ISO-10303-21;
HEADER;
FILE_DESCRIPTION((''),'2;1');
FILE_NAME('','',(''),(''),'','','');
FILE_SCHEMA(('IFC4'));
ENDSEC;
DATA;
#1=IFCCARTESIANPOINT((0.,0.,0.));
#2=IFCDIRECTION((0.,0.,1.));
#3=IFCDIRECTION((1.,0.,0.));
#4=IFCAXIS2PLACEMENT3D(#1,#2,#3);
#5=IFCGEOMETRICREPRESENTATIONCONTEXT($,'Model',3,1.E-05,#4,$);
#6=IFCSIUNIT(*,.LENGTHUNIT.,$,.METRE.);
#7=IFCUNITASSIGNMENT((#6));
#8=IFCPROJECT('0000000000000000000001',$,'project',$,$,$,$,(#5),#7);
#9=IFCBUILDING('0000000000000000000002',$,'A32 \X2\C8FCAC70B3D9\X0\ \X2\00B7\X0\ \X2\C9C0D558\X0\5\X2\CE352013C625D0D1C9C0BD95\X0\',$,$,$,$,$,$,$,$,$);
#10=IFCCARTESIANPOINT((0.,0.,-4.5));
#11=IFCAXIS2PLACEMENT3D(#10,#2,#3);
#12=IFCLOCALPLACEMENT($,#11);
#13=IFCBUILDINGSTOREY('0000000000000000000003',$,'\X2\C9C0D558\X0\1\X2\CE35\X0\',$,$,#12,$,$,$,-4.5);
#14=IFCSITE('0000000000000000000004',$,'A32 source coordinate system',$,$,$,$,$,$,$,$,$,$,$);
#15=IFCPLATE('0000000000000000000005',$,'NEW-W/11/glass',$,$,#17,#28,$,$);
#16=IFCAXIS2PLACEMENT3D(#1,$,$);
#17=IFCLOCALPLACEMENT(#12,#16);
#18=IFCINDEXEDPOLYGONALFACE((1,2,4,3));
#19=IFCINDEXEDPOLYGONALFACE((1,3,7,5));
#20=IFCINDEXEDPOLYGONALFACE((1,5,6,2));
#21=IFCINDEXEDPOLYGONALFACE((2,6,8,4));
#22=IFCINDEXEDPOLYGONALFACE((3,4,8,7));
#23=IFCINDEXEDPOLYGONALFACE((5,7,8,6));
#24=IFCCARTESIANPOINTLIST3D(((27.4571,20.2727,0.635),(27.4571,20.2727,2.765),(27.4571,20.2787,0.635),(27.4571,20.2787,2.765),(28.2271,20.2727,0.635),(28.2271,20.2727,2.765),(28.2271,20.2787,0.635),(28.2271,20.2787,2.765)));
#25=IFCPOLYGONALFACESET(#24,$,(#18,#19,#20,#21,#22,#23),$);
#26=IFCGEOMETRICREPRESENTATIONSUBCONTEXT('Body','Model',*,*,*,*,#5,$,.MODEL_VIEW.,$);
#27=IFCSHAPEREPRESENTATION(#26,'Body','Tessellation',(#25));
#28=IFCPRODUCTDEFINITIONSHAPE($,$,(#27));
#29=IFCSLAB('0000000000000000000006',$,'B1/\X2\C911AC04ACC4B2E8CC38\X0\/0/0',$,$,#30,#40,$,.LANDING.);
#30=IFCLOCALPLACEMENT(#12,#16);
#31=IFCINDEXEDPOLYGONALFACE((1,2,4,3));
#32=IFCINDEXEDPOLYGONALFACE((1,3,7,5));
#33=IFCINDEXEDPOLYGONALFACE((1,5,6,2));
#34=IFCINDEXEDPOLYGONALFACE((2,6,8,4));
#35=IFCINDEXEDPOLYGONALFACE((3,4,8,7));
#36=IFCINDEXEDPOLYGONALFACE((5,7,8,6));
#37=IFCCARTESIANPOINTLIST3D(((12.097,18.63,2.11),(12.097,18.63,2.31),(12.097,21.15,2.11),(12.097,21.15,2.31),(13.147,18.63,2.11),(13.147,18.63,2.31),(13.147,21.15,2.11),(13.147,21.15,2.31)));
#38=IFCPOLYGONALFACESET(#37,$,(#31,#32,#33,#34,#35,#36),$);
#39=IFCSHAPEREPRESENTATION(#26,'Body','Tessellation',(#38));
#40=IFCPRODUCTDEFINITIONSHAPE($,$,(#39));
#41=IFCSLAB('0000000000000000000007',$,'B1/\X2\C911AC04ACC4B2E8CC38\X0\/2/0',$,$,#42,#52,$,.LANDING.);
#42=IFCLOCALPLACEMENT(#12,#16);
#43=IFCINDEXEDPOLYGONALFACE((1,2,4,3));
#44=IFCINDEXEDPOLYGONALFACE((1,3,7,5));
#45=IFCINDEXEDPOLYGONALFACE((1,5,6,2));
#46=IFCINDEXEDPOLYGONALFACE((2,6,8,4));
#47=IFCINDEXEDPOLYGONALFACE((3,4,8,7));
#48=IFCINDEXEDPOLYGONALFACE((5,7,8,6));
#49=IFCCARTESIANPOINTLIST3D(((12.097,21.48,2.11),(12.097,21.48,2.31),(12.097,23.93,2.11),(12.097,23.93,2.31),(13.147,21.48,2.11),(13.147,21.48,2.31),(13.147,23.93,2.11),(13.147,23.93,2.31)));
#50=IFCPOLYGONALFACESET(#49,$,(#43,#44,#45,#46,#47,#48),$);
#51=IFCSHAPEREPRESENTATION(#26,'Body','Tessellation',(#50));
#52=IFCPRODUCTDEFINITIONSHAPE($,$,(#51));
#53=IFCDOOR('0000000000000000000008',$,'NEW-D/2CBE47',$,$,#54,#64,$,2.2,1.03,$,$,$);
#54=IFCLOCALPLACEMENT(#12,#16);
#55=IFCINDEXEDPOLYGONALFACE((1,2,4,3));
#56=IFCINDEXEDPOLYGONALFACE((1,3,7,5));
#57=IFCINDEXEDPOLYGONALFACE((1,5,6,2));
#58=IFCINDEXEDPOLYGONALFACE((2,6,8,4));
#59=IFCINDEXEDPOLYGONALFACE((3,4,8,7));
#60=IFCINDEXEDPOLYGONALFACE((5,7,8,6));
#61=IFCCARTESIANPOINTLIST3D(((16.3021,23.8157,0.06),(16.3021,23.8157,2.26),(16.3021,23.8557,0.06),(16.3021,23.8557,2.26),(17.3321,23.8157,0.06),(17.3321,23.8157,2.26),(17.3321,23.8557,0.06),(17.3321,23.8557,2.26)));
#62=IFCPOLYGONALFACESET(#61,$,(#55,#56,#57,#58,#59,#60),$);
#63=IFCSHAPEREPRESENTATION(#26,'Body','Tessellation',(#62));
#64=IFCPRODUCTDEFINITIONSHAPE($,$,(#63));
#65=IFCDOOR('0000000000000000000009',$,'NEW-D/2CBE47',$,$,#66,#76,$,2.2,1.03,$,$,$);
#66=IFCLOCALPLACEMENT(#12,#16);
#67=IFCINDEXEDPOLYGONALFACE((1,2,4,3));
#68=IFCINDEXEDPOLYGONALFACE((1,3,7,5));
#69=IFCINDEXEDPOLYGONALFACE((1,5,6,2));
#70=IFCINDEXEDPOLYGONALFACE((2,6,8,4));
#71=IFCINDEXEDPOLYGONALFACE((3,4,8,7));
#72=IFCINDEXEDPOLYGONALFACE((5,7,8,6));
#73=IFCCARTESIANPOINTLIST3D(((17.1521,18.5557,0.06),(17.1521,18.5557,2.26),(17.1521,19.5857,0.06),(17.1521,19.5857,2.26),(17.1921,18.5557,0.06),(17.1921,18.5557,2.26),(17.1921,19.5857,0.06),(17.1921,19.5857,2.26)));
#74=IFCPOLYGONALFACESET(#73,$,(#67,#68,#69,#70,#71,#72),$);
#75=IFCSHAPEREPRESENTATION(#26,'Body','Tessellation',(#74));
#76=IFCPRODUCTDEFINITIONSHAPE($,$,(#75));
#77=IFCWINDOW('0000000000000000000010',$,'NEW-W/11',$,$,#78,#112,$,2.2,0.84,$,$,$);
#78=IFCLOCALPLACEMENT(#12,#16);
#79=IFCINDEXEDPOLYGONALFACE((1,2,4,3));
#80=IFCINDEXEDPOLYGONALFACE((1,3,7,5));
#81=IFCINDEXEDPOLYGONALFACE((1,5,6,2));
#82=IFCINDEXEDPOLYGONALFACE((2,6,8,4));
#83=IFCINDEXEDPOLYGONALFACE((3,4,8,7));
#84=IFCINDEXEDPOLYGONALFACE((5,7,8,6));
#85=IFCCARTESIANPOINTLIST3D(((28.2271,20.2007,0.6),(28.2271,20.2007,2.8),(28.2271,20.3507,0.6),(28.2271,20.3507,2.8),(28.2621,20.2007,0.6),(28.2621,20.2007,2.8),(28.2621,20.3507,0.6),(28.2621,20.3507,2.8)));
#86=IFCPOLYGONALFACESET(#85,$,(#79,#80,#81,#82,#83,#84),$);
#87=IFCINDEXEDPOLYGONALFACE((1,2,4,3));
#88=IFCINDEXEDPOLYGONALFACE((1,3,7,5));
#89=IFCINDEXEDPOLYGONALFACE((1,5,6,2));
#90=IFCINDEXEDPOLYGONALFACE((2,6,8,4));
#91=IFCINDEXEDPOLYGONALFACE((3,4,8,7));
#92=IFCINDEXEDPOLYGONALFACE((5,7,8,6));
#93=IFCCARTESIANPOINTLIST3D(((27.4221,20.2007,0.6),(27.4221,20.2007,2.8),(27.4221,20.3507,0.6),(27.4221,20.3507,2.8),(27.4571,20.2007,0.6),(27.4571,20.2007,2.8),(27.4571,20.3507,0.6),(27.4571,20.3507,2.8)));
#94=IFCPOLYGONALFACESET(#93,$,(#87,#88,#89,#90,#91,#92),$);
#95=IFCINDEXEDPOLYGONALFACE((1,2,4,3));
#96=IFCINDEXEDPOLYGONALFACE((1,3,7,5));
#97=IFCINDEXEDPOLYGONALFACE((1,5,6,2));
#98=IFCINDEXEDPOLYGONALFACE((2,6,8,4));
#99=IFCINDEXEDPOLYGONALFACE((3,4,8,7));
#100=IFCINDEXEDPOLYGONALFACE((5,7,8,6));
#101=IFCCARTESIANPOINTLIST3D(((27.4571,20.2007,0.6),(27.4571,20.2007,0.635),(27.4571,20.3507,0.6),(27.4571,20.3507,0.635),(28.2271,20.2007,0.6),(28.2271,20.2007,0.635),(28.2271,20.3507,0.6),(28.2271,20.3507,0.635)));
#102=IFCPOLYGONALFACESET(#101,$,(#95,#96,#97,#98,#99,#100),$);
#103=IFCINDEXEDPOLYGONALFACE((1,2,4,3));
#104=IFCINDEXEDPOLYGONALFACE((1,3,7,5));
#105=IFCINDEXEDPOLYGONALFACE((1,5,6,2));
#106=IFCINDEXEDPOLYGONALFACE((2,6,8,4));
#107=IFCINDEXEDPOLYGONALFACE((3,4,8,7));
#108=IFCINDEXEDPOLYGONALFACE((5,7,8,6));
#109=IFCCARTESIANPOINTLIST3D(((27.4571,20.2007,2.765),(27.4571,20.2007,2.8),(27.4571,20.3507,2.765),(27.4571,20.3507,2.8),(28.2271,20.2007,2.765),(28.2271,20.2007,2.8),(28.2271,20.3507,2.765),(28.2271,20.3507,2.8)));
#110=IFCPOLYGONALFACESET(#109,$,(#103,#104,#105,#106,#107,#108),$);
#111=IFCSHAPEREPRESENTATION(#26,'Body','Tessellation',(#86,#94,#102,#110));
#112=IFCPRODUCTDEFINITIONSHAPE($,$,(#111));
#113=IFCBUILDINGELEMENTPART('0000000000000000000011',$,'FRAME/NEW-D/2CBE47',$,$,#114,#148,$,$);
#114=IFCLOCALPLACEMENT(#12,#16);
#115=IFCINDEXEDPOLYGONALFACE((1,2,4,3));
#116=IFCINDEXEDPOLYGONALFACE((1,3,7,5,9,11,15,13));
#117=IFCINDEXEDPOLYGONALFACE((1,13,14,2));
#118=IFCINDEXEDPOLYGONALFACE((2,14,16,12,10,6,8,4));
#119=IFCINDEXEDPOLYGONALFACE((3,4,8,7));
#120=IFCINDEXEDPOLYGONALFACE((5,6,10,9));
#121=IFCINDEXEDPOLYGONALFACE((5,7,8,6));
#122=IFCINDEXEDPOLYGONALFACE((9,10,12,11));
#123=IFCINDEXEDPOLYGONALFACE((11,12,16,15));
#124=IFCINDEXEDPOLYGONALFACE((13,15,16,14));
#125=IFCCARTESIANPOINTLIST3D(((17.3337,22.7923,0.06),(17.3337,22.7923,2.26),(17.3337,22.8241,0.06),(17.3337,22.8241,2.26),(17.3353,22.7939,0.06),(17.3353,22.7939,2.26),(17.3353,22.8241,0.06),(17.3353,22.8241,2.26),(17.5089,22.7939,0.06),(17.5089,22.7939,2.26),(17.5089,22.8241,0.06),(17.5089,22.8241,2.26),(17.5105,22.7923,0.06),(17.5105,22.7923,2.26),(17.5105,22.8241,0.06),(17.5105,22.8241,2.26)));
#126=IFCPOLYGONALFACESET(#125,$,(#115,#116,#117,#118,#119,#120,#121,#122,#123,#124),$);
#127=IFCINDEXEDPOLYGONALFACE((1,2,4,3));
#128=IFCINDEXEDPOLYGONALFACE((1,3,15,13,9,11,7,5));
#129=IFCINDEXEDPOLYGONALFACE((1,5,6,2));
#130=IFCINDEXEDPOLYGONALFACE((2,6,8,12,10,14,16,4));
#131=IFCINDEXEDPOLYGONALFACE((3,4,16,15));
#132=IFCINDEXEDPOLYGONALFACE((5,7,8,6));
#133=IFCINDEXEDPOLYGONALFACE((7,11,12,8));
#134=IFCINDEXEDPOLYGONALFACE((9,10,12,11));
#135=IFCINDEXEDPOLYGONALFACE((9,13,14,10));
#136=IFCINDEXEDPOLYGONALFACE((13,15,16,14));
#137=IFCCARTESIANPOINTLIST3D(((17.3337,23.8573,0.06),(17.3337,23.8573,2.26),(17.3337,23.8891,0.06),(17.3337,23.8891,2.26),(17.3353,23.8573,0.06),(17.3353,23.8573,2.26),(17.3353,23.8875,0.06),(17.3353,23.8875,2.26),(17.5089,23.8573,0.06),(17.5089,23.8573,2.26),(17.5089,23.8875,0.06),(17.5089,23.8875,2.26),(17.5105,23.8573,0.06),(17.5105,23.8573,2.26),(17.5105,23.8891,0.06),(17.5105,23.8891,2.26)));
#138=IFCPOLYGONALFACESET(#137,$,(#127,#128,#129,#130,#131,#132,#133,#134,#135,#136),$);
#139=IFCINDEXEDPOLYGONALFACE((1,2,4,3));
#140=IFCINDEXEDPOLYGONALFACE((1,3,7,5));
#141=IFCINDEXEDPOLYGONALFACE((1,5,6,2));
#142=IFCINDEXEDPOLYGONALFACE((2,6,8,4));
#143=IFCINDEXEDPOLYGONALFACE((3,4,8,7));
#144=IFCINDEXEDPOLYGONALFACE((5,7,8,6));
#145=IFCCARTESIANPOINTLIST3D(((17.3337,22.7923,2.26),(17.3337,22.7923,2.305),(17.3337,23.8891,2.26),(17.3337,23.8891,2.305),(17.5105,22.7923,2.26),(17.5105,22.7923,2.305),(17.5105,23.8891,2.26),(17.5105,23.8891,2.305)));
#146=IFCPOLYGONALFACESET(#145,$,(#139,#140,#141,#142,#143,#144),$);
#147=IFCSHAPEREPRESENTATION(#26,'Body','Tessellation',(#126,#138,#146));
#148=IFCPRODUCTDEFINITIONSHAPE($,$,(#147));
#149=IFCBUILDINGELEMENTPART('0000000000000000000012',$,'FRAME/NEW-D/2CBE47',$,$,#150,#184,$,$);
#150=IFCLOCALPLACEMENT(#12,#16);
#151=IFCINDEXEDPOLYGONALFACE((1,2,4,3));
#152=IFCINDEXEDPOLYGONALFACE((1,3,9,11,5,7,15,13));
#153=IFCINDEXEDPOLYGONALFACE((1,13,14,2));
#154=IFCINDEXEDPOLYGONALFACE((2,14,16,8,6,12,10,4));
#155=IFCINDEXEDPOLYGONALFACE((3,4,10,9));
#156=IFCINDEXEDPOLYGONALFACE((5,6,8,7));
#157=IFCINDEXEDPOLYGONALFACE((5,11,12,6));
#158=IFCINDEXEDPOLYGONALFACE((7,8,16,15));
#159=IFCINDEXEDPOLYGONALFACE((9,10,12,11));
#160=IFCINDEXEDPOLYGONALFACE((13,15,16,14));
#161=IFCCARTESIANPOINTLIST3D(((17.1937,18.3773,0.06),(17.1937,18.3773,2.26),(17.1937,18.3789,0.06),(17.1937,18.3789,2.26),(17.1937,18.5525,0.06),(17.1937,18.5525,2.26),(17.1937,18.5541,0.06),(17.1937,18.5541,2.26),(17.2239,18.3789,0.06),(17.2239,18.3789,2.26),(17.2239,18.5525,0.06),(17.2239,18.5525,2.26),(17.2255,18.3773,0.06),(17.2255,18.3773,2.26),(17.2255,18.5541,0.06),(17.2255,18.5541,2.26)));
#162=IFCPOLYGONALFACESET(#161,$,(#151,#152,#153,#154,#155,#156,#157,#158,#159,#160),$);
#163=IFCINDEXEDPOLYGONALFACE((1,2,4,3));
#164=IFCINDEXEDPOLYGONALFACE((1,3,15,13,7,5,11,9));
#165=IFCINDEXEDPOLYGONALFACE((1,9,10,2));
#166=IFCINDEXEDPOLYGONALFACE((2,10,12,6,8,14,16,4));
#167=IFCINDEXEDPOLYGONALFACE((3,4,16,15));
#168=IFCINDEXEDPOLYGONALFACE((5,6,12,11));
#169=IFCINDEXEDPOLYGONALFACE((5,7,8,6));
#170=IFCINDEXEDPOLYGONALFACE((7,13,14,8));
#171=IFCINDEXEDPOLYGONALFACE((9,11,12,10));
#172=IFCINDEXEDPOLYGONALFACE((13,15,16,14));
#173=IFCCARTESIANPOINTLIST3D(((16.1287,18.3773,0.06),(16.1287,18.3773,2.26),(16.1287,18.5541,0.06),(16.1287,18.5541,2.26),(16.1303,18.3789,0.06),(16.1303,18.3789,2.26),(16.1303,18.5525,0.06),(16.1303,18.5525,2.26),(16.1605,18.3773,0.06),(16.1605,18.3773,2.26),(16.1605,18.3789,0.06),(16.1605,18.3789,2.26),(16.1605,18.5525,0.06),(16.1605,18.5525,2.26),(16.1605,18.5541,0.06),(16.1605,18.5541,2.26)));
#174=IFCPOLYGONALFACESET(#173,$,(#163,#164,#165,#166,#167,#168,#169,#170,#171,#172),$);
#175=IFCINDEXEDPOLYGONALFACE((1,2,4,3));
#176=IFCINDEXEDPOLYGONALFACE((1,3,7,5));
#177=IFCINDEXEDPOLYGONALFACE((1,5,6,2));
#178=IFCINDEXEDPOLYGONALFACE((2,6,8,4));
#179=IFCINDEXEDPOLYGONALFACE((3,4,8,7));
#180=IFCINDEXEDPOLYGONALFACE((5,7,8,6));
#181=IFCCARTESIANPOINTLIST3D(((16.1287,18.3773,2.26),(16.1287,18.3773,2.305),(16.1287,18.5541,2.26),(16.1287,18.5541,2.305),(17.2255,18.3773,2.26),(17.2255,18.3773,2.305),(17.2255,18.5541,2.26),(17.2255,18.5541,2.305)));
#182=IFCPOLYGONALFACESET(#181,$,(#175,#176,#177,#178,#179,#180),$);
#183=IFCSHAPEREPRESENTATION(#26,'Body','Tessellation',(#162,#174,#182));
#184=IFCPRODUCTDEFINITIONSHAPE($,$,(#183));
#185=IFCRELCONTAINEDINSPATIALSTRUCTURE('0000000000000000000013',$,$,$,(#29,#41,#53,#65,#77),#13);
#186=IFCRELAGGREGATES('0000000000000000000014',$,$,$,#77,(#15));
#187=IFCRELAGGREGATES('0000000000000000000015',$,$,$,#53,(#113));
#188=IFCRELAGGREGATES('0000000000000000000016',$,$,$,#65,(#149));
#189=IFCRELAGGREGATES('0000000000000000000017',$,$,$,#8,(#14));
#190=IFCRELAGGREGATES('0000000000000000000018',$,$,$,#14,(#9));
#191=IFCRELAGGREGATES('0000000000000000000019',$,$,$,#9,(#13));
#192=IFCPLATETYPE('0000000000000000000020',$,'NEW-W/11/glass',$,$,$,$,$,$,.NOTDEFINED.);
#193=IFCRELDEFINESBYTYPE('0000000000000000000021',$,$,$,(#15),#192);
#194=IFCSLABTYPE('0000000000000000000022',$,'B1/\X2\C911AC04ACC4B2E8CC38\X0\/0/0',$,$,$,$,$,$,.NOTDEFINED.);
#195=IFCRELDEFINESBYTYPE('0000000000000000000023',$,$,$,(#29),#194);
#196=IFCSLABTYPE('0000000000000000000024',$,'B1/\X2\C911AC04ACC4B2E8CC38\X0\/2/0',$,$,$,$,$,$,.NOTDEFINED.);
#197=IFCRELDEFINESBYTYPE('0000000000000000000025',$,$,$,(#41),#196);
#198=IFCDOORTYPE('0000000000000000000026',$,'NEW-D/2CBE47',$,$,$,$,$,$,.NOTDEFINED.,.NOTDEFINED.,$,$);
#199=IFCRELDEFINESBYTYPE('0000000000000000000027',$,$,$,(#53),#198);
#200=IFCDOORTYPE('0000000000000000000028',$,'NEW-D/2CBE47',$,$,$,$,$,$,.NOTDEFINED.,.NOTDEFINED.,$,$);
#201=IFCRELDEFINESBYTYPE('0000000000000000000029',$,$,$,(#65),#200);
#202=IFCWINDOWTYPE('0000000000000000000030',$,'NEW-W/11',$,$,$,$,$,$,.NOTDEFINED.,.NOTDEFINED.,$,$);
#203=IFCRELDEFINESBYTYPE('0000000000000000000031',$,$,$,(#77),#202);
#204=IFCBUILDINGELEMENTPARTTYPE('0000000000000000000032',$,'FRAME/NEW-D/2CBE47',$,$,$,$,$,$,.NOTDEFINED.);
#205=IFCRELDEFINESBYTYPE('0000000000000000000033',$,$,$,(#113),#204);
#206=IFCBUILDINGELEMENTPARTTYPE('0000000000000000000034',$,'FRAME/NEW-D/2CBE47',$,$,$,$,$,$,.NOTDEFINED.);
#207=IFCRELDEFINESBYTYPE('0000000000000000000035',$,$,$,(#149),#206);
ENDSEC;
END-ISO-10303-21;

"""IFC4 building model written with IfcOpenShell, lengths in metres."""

from ifc_helpers import new_model, si_unit, frame, origin, origin_with_axes, place, context, subcontext, project, spatial, polyline, outline, extrude, source, transform, mapped, type_object, type_shapes, element, aggregate, save


model = new_model("IFC4")

# Units and contexts
model_context = context("Model", 3, precision=1e-05, world=origin_with_axes())
body_context = subcontext(model_context, "Body", "Model", "MODEL_VIEW")
ifc_project = project(units=[si_unit("LENGTHUNIT", "METRE")], contexts=[model_context])

# Plate
storey_placement = place(None, frame((0.0, 0.0, -4.5), z_axis=(0.0, 0.0, 1.0), x_axis=(1.0, 0.0, 0.0)))
plate_type_1 = type_object("IfcPlateType", Name="NEW-W/11/glass", PredefinedType="NOTDEFINED")
shared_shape_1 = source(origin(), body_context, "Body", "SweptSolid", [
    extrude(outline(polyline([(28.2271, 20.2727), (27.4571, 20.2727), (27.4571, 20.2787), (28.2271, 20.2787), (28.2271, 20.2727)])), frame((0.0, 0.0, 0.635)), (0.0, 0.0, 1.0), 2.13),
])
type_shapes(plate_type_1, [shared_shape_1])
window_1_placement = place(storey_placement, origin_with_axes())
plate_1_placement = place(window_1_placement, origin_with_axes())
plate_1 = element("IfcPlate", 1, at=plate_1_placement, type_object=plate_type_1, Name="NEW-W/11/glass", context=body_context, shape_type="MappedRepresentation", body=[
    mapped(shared_shape_1, transform((0.0, 0.0, 0.0), scale=1.0)),
])

# Site, building, storey
site = spatial("IfcSite", under=ifc_project, Name="A32 source coordinate system")
building = spatial("IfcBuilding", under=site, Name="A32 주거동 · 지하5층–옥탑지붕")
storey = spatial("IfcBuildingStorey", under=building, at=storey_placement, Name="지하1층", Elevation=-4.5)

# Slabs
slab_type_1 = type_object("IfcSlabType", Name="B1/중간계단참/0/0", PredefinedType="NOTDEFINED")
shared_shape_2 = source(origin(), body_context, "Body", "SweptSolid", [
    extrude(outline(polyline([(13.147, 18.63), (12.097, 18.63), (12.097, 21.15), (13.147, 21.15), (13.147, 18.63)])), frame((0.0, 0.0, 2.11)), (0.0, 0.0, 1.0), 0.2),
])
type_shapes(slab_type_1, [shared_shape_2])
slab_1_placement = place(storey_placement, origin_with_axes())
element("IfcSlab", 2, at=slab_1_placement, inside=storey, type_object=slab_type_1, Name="B1/중간계단참/0/0", PredefinedType="LANDING", context=body_context, shape_type="MappedRepresentation", body=[
    mapped(shared_shape_2, transform((0.0, 0.0, 0.0), scale=1.0)),
])
slab_type_2 = type_object("IfcSlabType", Name="B1/중간계단참/2/0", PredefinedType="NOTDEFINED")
shared_shape_3 = source(origin(), body_context, "Body", "SweptSolid", [
    extrude(outline(polyline([(13.147, 21.48), (12.097, 21.48), (12.097, 23.93), (13.147, 23.93), (13.147, 21.48)])), frame((0.0, 0.0, 2.11)), (0.0, 0.0, 1.0), 0.2),
])
type_shapes(slab_type_2, [shared_shape_3])
slab_2_placement = place(storey_placement, origin_with_axes())
element("IfcSlab", 3, at=slab_2_placement, inside=storey, type_object=slab_type_2, Name="B1/중간계단참/2/0", PredefinedType="LANDING", context=body_context, shape_type="MappedRepresentation", body=[
    mapped(shared_shape_3, transform((0.0, 0.0, 0.0), scale=1.0)),
])

# Doors
door_type_1 = type_object("IfcDoorType", Name="NEW-D/2CBE47", OperationType="NOTDEFINED", PredefinedType="NOTDEFINED")
shared_shape_4 = source(origin(), body_context, "Body", "SweptSolid", [
    extrude(outline(polyline([(17.3321, 23.8557), (17.3321, 23.8157), (16.3021, 23.8157), (16.3021, 23.8557), (17.3321, 23.8557)])), frame((0.0, 0.0, 0.06)), (0.0, 0.0, 1.0), 2.2),
])
type_shapes(door_type_1, [shared_shape_4])
door_1_placement = place(storey_placement, origin_with_axes())
door_1 = element("IfcDoor", 4, at=door_1_placement, inside=storey, type_object=door_type_1, Name="NEW-D/2CBE47", OverallHeight=2.2, OverallWidth=1.03, context=body_context, shape_type="MappedRepresentation", body=[
    mapped(shared_shape_4, transform((0.0, 0.0, 0.0), scale=1.0)),
])
door_type_2 = type_object("IfcDoorType", Name="NEW-D/2CBE47", OperationType="NOTDEFINED", PredefinedType="NOTDEFINED")
shared_shape_5 = source(origin(), body_context, "Body", "SweptSolid", [
    extrude(outline(polyline([(17.1921, 18.5557), (17.1521, 18.5557), (17.1521, 19.5857), (17.1921, 19.5857), (17.1921, 18.5557)])), frame((0.0, 0.0, 0.06)), (0.0, 0.0, 1.0), 2.2),
])
type_shapes(door_type_2, [shared_shape_5])
door_2_placement = place(storey_placement, origin_with_axes())
door_2 = element("IfcDoor", 5, at=door_2_placement, inside=storey, type_object=door_type_2, Name="NEW-D/2CBE47", OverallHeight=2.2, OverallWidth=1.03, context=body_context, shape_type="MappedRepresentation", body=[
    mapped(shared_shape_5, transform((0.0, 0.0, 0.0), scale=1.0)),
])

# Window
window_type_1 = type_object("IfcWindowType", Name="NEW-W/11", PartitioningType="NOTDEFINED", PredefinedType="NOTDEFINED")
shared_shape_6 = source(origin(), body_context, "Body", "SweptSolid", [
    extrude(outline(polyline([(28.2271, 20.2007), (28.2271, 20.3507), (28.2621, 20.3507), (28.2621, 20.2007), (28.2271, 20.2007)])), frame((0.0, 0.0, 0.6)), (0.0, 0.0, 1.0), 2.2),
    extrude(outline(polyline([(27.4221, 20.2007), (27.4221, 20.3507), (27.4571, 20.3507), (27.4571, 20.2007), (27.4221, 20.2007)])), frame((0.0, 0.0, 0.6)), (0.0, 0.0, 1.0), 2.2),
    extrude(outline(polyline([(28.2271, 20.2007), (28.2271, 20.3507), (27.4571, 20.3507), (27.4571, 20.2007), (28.2271, 20.2007)])), frame((0.0, 0.0, 0.6)), (0.0, 0.0, 1.0), 0.035),
    extrude(outline(polyline([(28.2271, 20.2007), (28.2271, 20.3507), (27.4571, 20.3507), (27.4571, 20.2007), (28.2271, 20.2007)])), frame((0.0, 0.0, 2.765)), (0.0, 0.0, 1.0), 0.035),
])
type_shapes(window_type_1, [shared_shape_6])
window_1 = element("IfcWindow", 6, at=window_1_placement, inside=storey, type_object=window_type_1, Name="NEW-W/11", OverallHeight=2.2, OverallWidth=0.84, context=body_context, shape_type="MappedRepresentation", body=[
    mapped(shared_shape_6, transform((0.0, 0.0, 0.0), scale=1.0)),
])
aggregate(window_1, [plate_1])

# Building element parts
building_element_part_type_1 = type_object("IfcBuildingElementPartType", Name="FRAME/NEW-D/2CBE47", PredefinedType="NOTDEFINED")
shared_shape_7 = source(origin(), body_context, "Body", "SweptSolid", [
    extrude(outline(polyline([(17.3353, 22.7939), (17.5089, 22.7939), (17.5089, 22.8241), (17.5105, 22.8241), (17.5105, 22.7923), (17.3337, 22.7923), (17.3337, 22.8241), (17.3353, 22.8241), (17.3353, 22.7939)])), frame((0.0, 0.0, 0.06)), (0.0, 0.0, 1.0), 2.2),
    extrude(outline(polyline([(17.5105, 23.8891), (17.5105, 23.8573), (17.5089, 23.8573), (17.5089, 23.8875), (17.3353, 23.8875), (17.3353, 23.8573), (17.3337, 23.8573), (17.3337, 23.8891), (17.5105, 23.8891)])), frame((0.0, 0.0, 0.06)), (0.0, 0.0, 1.0), 2.2),
    extrude(outline(polyline([(17.5105, 22.7923), (17.5105, 23.8891), (17.3337, 23.8891), (17.3337, 22.7923), (17.5105, 22.7923)])), frame((0.0, 0.0, 2.26)), (0.0, 0.0, 1.0), 0.045),
])
type_shapes(building_element_part_type_1, [shared_shape_7])
building_element_part_1_placement = place(door_1_placement, origin_with_axes())
building_element_part_1 = element("IfcBuildingElementPart", 7, at=building_element_part_1_placement, type_object=building_element_part_type_1, Name="FRAME/NEW-D/2CBE47", context=body_context, shape_type="MappedRepresentation", body=[
    mapped(shared_shape_7, transform((0.0, 0.0, 0.0), scale=1.0)),
])
aggregate(door_1, [building_element_part_1])
building_element_part_type_2 = type_object("IfcBuildingElementPartType", Name="FRAME/NEW-D/2CBE47", PredefinedType="NOTDEFINED")
shared_shape_8 = source(origin(), body_context, "Body", "SweptSolid", [
    extrude(outline(polyline([(17.2255, 18.3773), (17.1937, 18.3773), (17.1937, 18.3789), (17.2239, 18.3789), (17.2239, 18.5525), (17.1937, 18.5525), (17.1937, 18.5541), (17.2255, 18.5541), (17.2255, 18.3773)])), frame((0.0, 0.0, 0.06)), (0.0, 0.0, 1.0), 2.2),
    extrude(outline(polyline([(16.1303, 18.5525), (16.1303, 18.3789), (16.1605, 18.3789), (16.1605, 18.3773), (16.1287, 18.3773), (16.1287, 18.5541), (16.1605, 18.5541), (16.1605, 18.5525), (16.1303, 18.5525)])), frame((0.0, 0.0, 0.06)), (0.0, 0.0, 1.0), 2.2),
    extrude(outline(polyline([(17.2255, 18.3773), (17.2255, 18.5541), (16.1287, 18.5541), (16.1287, 18.3773), (17.2255, 18.3773)])), frame((0.0, 0.0, 2.26)), (0.0, 0.0, 1.0), 0.045),
])
type_shapes(building_element_part_type_2, [shared_shape_8])
building_element_part_2_placement = place(door_2_placement, origin_with_axes())
building_element_part_2 = element("IfcBuildingElementPart", 8, at=building_element_part_2_placement, type_object=building_element_part_type_2, Name="FRAME/NEW-D/2CBE47", context=body_context, shape_type="MappedRepresentation", body=[
    mapped(shared_shape_8, transform((0.0, 0.0, 0.0), scale=1.0)),
])
aggregate(door_2, [building_element_part_2])

save(model, "model.ifc")
